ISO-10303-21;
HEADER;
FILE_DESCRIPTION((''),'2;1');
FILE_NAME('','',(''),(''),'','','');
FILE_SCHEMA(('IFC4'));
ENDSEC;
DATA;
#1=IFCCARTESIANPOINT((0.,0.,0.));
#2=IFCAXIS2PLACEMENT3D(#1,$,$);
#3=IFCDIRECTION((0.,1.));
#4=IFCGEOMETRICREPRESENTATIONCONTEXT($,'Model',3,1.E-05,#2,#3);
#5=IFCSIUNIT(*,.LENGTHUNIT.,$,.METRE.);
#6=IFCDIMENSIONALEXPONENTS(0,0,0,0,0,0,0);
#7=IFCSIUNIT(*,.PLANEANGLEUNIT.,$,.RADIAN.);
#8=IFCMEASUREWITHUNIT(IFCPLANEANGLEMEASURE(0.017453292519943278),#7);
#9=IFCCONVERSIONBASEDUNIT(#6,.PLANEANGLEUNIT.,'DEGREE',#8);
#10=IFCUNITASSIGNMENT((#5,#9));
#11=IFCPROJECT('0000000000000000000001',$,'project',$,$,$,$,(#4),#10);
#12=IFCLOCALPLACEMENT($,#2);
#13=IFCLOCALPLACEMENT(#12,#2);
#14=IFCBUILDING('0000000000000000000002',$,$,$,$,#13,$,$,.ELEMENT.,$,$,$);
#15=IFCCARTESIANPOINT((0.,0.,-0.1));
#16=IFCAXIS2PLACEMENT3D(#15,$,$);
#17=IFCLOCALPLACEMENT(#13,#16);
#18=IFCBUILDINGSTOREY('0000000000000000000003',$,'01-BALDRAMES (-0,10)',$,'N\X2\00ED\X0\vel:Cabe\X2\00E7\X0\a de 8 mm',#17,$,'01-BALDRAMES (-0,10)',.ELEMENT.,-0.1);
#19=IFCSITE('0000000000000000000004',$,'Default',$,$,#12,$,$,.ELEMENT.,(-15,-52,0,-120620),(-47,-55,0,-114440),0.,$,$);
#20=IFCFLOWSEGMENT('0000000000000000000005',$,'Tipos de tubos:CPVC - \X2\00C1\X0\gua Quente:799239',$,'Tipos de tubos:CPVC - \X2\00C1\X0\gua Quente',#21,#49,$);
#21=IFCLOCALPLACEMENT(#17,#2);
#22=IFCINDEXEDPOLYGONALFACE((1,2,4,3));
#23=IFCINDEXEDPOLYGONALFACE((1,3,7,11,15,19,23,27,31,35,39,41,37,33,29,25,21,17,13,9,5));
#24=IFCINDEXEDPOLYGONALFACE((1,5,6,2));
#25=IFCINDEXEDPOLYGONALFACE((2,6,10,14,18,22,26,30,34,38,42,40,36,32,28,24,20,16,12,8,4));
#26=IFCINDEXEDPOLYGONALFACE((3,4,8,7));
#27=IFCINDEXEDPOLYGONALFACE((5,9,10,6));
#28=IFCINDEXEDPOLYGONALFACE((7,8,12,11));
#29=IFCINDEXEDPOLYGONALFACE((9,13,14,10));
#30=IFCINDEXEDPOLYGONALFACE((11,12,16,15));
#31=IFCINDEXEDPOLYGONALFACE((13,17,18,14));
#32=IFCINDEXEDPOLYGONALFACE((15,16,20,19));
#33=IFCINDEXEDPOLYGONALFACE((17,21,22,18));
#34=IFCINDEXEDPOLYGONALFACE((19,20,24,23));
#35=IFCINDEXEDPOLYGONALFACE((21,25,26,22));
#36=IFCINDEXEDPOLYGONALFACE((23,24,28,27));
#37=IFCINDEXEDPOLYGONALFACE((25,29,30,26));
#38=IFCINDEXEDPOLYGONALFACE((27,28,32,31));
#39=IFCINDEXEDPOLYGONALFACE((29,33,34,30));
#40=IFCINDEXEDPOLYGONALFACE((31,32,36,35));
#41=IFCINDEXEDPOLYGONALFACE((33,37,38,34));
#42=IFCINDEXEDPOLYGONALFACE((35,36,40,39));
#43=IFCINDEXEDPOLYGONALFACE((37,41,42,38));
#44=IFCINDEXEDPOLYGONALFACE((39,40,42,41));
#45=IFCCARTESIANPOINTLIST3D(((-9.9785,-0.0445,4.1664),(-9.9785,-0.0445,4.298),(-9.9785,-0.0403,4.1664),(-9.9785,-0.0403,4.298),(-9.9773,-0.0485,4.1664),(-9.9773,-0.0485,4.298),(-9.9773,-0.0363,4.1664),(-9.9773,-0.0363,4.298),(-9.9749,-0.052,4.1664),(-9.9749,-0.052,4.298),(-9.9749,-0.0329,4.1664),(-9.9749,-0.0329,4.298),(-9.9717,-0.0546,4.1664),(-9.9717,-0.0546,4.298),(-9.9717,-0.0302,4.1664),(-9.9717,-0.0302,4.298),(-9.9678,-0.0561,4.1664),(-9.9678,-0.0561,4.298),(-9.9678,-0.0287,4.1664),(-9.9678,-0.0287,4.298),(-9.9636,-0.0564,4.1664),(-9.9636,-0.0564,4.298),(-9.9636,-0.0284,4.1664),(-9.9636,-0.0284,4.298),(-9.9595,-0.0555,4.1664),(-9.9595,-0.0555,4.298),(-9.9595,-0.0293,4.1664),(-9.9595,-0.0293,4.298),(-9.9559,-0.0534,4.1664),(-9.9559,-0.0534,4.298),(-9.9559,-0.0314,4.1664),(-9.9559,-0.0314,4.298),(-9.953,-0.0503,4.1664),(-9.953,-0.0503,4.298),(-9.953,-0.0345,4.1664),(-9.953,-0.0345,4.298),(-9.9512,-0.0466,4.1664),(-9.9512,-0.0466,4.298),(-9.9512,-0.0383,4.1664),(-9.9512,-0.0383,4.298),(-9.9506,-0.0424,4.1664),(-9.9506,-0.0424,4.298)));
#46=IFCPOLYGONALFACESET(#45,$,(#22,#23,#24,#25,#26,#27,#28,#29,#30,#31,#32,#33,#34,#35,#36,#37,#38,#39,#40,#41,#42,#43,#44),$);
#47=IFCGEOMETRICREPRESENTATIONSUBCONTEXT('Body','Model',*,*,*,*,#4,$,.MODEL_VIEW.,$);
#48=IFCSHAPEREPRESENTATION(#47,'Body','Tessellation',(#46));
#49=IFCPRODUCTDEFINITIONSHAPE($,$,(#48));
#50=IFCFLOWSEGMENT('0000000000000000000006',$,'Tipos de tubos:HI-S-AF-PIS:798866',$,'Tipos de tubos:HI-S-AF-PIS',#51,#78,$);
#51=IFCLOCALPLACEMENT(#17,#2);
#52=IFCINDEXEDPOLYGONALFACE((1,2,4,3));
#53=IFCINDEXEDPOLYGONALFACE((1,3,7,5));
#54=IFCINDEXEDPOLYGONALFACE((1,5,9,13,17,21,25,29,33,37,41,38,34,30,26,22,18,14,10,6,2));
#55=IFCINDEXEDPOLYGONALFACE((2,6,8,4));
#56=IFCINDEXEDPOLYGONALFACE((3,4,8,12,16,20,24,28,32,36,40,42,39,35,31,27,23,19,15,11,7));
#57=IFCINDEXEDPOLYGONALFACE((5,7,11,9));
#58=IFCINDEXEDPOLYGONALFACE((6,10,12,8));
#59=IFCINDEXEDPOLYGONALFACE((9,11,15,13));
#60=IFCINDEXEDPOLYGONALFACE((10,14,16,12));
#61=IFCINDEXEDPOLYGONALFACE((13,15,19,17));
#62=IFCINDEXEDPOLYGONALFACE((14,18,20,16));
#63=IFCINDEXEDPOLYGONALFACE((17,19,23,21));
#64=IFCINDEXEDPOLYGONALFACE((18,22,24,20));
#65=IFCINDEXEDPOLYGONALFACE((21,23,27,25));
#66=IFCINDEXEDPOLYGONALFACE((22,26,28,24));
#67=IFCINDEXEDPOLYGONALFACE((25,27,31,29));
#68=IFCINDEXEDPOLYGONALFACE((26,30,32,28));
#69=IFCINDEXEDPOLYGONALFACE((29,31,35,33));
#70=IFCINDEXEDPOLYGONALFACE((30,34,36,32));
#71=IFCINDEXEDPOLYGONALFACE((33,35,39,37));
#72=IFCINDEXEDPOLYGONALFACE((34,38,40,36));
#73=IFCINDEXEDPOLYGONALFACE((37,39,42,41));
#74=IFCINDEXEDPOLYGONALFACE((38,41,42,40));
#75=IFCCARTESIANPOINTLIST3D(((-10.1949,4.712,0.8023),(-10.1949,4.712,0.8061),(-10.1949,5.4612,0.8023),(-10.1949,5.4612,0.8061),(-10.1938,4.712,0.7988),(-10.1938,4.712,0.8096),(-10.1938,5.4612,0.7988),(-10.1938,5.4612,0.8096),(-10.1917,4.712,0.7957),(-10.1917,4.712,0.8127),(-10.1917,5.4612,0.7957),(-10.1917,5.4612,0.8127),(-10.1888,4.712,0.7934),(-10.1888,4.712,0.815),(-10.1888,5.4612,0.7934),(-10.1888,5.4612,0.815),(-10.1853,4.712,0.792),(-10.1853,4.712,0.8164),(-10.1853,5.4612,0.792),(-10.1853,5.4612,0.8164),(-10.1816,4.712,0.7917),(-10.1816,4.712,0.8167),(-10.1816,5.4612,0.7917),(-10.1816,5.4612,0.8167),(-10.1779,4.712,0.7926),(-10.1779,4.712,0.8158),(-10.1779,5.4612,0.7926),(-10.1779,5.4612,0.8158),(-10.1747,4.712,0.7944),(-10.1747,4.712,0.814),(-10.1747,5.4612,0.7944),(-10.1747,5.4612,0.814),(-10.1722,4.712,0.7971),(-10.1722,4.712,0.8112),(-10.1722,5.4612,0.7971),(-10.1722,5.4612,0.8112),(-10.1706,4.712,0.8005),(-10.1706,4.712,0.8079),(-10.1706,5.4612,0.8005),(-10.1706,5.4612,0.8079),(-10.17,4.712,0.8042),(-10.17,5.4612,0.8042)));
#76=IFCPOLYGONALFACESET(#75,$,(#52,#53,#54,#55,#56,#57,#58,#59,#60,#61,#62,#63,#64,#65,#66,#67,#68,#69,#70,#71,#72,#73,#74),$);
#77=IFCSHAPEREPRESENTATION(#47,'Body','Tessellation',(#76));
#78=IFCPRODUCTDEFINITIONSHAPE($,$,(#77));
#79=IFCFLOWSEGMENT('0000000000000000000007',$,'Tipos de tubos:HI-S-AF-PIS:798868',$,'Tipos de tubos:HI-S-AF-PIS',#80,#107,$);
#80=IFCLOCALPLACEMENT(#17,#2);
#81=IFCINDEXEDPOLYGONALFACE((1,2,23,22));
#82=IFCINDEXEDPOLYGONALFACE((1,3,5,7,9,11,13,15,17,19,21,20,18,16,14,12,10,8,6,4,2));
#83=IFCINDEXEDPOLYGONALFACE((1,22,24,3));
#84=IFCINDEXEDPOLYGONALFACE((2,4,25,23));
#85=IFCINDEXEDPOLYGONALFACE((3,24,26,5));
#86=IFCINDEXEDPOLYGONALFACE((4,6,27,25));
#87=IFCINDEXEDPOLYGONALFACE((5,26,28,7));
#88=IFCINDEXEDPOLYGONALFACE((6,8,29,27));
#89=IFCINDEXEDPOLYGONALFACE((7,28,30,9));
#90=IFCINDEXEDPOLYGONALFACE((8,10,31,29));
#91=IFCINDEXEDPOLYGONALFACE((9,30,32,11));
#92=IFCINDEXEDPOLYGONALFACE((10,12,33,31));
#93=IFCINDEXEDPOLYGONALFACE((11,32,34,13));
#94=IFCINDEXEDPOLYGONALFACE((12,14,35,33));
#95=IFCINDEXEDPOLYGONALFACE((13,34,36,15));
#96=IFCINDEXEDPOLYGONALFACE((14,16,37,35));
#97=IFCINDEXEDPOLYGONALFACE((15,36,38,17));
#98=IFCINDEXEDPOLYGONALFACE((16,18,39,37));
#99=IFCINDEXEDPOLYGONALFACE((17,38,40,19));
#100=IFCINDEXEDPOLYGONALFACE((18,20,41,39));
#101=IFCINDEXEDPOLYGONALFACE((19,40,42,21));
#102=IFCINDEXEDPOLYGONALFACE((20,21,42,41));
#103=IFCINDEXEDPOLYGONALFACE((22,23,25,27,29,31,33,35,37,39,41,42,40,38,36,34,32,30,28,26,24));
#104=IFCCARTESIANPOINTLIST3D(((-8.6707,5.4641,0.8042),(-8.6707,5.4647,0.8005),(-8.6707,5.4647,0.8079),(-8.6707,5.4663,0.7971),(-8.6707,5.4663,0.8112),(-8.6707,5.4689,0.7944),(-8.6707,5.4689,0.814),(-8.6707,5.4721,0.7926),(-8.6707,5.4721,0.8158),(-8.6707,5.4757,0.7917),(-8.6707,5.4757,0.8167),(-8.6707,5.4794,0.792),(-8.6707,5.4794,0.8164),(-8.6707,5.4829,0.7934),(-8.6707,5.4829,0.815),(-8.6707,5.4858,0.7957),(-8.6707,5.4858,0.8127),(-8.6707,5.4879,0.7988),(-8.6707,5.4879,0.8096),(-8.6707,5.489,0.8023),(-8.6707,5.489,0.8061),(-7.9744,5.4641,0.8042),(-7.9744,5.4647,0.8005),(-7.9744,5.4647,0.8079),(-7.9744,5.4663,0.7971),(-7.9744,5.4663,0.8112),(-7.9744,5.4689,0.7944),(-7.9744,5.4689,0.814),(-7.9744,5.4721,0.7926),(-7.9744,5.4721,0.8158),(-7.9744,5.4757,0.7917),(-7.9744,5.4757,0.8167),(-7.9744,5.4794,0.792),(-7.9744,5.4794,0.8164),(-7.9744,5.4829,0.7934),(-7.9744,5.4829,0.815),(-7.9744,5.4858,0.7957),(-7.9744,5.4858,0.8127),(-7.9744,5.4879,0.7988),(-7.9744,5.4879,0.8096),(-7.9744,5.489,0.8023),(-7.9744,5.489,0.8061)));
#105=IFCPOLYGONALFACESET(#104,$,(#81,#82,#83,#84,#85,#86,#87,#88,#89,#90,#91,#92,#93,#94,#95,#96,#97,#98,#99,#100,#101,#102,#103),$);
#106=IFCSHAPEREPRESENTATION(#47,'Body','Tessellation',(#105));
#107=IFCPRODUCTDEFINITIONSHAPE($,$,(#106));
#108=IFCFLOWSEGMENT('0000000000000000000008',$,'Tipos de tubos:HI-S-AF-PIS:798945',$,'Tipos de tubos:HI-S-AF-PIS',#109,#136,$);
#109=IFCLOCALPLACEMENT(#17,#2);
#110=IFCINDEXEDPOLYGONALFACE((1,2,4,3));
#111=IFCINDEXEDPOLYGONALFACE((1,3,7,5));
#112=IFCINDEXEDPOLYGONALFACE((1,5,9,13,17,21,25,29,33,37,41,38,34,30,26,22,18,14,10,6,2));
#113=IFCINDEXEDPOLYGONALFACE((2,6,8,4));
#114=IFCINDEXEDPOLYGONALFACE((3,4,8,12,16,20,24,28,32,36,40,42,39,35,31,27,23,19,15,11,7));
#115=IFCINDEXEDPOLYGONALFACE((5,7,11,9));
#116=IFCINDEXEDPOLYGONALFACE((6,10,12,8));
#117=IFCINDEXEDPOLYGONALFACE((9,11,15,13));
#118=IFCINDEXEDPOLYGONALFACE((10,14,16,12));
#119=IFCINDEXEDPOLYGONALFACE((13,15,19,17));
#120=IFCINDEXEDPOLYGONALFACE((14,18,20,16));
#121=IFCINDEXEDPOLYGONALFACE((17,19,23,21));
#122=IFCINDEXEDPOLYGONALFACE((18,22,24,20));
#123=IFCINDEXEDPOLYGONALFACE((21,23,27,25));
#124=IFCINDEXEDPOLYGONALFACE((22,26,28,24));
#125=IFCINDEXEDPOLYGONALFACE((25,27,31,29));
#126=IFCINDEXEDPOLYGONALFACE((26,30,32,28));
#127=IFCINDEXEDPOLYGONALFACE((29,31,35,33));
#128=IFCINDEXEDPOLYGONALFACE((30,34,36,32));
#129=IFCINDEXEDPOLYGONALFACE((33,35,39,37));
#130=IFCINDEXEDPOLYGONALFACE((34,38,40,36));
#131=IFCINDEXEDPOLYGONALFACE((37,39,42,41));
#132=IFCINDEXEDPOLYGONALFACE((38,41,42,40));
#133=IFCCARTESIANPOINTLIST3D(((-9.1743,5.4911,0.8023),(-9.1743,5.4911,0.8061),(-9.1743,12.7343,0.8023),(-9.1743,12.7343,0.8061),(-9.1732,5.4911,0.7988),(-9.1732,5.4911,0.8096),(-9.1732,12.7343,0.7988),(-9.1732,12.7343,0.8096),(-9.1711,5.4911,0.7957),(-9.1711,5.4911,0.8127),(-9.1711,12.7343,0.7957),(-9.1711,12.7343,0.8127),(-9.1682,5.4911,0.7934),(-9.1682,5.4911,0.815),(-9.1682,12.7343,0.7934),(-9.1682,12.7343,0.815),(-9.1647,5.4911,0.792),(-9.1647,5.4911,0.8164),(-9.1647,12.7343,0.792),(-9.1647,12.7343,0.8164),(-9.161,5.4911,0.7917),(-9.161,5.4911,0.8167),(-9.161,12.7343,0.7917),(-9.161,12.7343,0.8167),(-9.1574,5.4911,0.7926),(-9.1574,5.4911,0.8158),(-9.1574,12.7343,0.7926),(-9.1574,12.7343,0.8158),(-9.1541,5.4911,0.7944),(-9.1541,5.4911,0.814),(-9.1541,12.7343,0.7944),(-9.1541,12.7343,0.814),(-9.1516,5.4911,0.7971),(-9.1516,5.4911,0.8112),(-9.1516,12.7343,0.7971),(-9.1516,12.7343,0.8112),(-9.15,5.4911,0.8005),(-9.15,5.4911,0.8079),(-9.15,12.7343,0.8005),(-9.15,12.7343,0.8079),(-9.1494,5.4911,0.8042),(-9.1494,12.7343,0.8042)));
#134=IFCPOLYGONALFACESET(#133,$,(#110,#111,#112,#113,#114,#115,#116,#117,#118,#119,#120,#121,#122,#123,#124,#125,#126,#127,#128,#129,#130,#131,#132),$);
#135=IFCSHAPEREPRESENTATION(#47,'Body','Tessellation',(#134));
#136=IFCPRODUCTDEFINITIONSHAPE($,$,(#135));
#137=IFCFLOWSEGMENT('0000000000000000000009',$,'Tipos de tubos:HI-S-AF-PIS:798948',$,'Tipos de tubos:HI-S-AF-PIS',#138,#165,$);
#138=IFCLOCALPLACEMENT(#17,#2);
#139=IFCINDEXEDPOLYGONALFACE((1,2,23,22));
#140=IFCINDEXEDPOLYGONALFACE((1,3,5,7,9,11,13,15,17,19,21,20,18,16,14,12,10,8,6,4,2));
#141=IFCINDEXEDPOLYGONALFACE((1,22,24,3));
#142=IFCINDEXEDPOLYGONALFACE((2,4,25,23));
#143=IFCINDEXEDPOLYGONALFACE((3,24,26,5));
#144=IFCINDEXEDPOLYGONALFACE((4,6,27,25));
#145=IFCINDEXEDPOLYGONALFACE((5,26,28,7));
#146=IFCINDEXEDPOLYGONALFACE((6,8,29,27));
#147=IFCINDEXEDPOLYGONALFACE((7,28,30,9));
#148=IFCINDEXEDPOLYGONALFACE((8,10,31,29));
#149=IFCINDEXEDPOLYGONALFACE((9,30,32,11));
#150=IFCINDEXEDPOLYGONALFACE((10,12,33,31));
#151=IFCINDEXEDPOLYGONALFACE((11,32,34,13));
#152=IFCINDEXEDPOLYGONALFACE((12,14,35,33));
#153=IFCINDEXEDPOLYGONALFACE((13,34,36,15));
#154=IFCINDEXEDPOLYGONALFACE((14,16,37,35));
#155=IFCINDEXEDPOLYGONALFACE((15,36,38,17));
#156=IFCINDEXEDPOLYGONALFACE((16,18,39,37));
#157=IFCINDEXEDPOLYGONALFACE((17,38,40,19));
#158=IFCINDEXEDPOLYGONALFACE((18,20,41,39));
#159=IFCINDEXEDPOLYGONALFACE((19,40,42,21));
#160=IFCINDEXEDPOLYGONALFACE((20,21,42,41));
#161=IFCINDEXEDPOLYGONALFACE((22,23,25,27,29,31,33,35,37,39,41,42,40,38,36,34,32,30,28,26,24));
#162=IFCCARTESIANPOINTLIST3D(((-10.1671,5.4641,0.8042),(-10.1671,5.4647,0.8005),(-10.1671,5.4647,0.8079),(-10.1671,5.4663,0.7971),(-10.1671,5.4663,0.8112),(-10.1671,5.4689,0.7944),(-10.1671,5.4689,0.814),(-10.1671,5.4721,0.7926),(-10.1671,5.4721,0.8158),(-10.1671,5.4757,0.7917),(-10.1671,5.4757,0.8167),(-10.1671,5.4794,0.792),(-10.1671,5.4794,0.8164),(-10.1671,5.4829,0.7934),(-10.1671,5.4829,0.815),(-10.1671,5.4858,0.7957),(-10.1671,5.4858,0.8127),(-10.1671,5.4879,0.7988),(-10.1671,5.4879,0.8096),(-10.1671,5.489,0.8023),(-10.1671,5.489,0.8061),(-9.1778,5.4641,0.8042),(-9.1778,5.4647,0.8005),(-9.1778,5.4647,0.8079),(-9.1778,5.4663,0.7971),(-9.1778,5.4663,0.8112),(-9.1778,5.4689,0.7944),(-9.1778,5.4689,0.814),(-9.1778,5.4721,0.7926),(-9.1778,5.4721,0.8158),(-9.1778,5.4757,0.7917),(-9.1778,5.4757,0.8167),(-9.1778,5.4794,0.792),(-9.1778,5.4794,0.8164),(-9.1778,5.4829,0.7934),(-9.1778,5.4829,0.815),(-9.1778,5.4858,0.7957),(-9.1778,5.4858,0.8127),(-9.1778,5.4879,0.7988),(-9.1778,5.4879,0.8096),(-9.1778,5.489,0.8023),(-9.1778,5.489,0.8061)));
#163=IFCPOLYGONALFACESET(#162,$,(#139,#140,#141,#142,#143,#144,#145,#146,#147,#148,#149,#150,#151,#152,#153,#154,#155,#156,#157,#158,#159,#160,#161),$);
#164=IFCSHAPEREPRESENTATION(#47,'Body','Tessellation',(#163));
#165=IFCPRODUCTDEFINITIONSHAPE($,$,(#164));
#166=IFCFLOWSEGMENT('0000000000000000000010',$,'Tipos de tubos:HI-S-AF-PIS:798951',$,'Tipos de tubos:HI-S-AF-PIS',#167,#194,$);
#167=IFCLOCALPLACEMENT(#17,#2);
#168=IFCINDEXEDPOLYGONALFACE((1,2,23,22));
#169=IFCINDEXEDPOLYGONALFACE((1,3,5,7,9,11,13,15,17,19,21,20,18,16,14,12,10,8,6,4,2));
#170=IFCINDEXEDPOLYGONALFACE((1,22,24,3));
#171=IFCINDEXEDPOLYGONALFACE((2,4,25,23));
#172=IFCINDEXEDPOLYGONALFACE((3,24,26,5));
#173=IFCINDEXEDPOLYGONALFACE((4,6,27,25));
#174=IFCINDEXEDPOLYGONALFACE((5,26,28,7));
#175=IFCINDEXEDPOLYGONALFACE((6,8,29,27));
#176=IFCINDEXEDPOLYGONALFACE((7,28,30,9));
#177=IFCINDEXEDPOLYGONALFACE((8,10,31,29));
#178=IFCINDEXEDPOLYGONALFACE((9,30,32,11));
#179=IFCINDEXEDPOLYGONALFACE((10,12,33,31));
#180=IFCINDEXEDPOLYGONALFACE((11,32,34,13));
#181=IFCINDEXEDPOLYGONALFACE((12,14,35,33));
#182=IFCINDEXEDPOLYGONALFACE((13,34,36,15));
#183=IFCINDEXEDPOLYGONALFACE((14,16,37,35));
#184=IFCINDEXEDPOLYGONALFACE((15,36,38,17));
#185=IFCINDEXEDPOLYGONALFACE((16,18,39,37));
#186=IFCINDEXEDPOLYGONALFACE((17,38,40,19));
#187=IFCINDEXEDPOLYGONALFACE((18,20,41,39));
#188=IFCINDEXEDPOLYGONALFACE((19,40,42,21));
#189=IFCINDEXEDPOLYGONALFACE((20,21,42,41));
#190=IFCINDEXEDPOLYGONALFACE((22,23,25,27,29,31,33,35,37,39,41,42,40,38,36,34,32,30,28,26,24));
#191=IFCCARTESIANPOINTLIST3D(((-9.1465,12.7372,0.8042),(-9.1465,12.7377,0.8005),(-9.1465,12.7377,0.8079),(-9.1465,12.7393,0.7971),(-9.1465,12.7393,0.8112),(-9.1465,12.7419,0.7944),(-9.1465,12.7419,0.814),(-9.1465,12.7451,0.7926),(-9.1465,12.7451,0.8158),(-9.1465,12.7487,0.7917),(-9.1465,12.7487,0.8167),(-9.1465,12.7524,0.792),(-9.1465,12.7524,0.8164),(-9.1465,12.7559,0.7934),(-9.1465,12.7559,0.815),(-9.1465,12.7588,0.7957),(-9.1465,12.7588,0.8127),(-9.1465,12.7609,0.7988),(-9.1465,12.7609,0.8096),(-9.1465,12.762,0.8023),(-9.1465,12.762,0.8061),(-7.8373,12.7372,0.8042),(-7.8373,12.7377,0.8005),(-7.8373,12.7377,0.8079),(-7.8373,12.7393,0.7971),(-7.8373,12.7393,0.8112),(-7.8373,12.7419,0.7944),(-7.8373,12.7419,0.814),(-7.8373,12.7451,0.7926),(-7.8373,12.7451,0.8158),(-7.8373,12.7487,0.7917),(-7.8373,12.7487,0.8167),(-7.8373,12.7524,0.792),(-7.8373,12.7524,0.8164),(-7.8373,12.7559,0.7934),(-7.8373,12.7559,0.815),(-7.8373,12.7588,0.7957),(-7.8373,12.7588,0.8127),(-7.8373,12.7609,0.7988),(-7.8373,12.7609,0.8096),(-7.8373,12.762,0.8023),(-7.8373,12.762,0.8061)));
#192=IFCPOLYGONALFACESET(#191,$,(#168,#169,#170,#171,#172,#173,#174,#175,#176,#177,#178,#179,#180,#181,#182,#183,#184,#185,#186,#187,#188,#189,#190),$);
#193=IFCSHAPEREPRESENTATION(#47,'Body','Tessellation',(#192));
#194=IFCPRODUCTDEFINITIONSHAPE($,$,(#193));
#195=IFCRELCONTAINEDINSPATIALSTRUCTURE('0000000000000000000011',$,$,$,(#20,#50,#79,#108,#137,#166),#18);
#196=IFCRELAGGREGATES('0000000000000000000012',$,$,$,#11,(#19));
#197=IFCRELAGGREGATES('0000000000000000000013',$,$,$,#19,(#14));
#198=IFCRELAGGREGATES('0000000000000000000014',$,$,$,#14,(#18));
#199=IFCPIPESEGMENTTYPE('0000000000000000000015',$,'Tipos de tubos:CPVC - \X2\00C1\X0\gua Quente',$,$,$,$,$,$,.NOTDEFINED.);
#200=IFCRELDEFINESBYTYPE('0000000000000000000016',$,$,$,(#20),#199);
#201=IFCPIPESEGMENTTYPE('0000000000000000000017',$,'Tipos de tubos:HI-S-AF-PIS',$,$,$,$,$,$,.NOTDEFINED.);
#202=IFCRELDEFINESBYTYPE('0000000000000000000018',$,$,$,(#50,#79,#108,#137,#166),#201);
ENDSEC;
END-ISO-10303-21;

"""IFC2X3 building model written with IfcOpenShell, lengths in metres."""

from ifc_helpers import new_model, entity, si_unit, converted_unit, direction, frame, frame_2d, origin, origin_2d_with_axis, place, context, subcontext, project, spatial, circle, extrude, type_object, element, save


model = new_model("IFC2X3")

# Units and contexts
model_context = context("Model", 3, precision=1e-05, world=origin(), true_north=direction((0.0, 1.0)))
body_context = subcontext(model_context, "Body", "Model", "MODEL_VIEW")
ifc_project = project(units=[si_unit("LENGTHUNIT", "METRE"), converted_unit("PLANEANGLEUNIT", "DEGREE", entity("IfcPlaneAngleMeasure", 0.017453292519943278), si_unit("PLANEANGLEUNIT", "RADIAN"), dimensions=[0, 0, 0, 0, 0, 0, 0])], contexts=[model_context])

# Site, building, storey
site_placement = place(None, origin())
site = spatial("IfcSite", under=ifc_project, at=site_placement, Name="Default", CompositionType="ELEMENT", RefLatitude=(-15, -52, 0, -120620), RefLongitude=(-47, -55, 0, -114440), RefElevation=0.0)
building_placement = place(site_placement, origin())
building = spatial("IfcBuilding", under=site, at=building_placement, CompositionType="ELEMENT")
storey_placement = place(building_placement, frame((0.0, 0.0, -0.1)))
storey = spatial("IfcBuildingStorey", under=building, at=storey_placement, Name="01-BALDRAMES (-0,10)", ObjectType="Nível:Cabeça de 8 mm", LongName="01-BALDRAMES (-0,10)", CompositionType="ELEMENT", Elevation=-0.1)

# Flow segments
pipe_segment_type_1 = type_object("IfcPipeSegmentType", Name="Tipos de tubos:CPVC - Água Quente", PredefinedType="NOTDEFINED")
flow_segment_1_placement = place(storey_placement, origin())
element("IfcFlowSegment", 1, at=flow_segment_1_placement, inside=storey, type_object=pipe_segment_type_1, Name="Tipos de tubos:CPVC - Água Quente:799239", ObjectType="Tipos de tubos:CPVC - Água Quente", context=body_context, shape_type="SweptSolid", body=[
    extrude(circle(Radius=0.0141, at=frame_2d((0.0, 0.0), x_axis=(1.0, 0.0))), frame((-9.9646, -0.0424, 4.1664)), (0.0, 0.0, 1.0), 0.1316),
])
pipe_segment_type_2 = type_object("IfcPipeSegmentType", Name="Tipos de tubos:HI-S-AF-PIS", PredefinedType="NOTDEFINED")
flow_segment_2_placement = place(storey_placement, origin())
element("IfcFlowSegment", 2, at=flow_segment_2_placement, inside=storey, type_object=pipe_segment_type_2, Name="Tipos de tubos:HI-S-AF-PIS:798866", ObjectType="Tipos de tubos:HI-S-AF-PIS", context=body_context, shape_type="SweptSolid", body=[
    extrude(circle(Radius=0.0125, at=origin_2d_with_axis()), frame((-10.1825, 4.712, 0.8042), z_axis=(0.0, 1.0, 0.0), x_axis=(1.0, 0.0, 0.0)), (0.0, 0.0, 1.0), 0.7492),
])
flow_segment_3_placement = place(storey_placement, origin())
element("IfcFlowSegment", 3, at=flow_segment_3_placement, inside=storey, type_object=pipe_segment_type_2, Name="Tipos de tubos:HI-S-AF-PIS:798868", ObjectType="Tipos de tubos:HI-S-AF-PIS", context=body_context, shape_type="SweptSolid", body=[
    extrude(circle(Radius=0.0125, at=origin_2d_with_axis()), frame((-8.6707, 5.4766, 0.8042), z_axis=(1.0, 0.0, 0.0), x_axis=(0.0, -1.0, 0.0)), (0.0, 0.0, 1.0), 0.6964),
])
flow_segment_4_placement = place(storey_placement, origin())
element("IfcFlowSegment", 4, at=flow_segment_4_placement, inside=storey, type_object=pipe_segment_type_2, Name="Tipos de tubos:HI-S-AF-PIS:798945", ObjectType="Tipos de tubos:HI-S-AF-PIS", context=body_context, shape_type="SweptSolid", body=[
    extrude(circle(Radius=0.0125, at=origin_2d_with_axis()), frame((-9.1619, 5.4911, 0.8042), z_axis=(0.0, 1.0, 0.0), x_axis=(1.0, 0.0, 0.0)), (0.0, 0.0, 1.0), 7.2431),
])
flow_segment_5_placement = place(storey_placement, origin())
element("IfcFlowSegment", 5, at=flow_segment_5_placement, inside=storey, type_object=pipe_segment_type_2, Name="Tipos de tubos:HI-S-AF-PIS:798948", ObjectType="Tipos de tubos:HI-S-AF-PIS", context=body_context, shape_type="SweptSolid", body=[
    extrude(circle(Radius=0.0125, at=origin_2d_with_axis()), frame((-10.1671, 5.4766, 0.8042), z_axis=(1.0, 0.0, 0.0), x_axis=(0.0, -1.0, 0.0)), (0.0, 0.0, 1.0), 0.9893),
])
flow_segment_6_placement = place(storey_placement, origin())
element("IfcFlowSegment", 6, at=flow_segment_6_placement, inside=storey, type_object=pipe_segment_type_2, Name="Tipos de tubos:HI-S-AF-PIS:798951", ObjectType="Tipos de tubos:HI-S-AF-PIS", context=body_context, shape_type="SweptSolid", body=[
    extrude(circle(Radius=0.0125, at=origin_2d_with_axis()), frame((-9.1465, 12.7497, 0.8042), z_axis=(1.0, 0.0, 0.0), x_axis=(0.0, -1.0, 0.0)), (0.0, 0.0, 1.0), 1.3092),
])

save(model, "model.ifc")
